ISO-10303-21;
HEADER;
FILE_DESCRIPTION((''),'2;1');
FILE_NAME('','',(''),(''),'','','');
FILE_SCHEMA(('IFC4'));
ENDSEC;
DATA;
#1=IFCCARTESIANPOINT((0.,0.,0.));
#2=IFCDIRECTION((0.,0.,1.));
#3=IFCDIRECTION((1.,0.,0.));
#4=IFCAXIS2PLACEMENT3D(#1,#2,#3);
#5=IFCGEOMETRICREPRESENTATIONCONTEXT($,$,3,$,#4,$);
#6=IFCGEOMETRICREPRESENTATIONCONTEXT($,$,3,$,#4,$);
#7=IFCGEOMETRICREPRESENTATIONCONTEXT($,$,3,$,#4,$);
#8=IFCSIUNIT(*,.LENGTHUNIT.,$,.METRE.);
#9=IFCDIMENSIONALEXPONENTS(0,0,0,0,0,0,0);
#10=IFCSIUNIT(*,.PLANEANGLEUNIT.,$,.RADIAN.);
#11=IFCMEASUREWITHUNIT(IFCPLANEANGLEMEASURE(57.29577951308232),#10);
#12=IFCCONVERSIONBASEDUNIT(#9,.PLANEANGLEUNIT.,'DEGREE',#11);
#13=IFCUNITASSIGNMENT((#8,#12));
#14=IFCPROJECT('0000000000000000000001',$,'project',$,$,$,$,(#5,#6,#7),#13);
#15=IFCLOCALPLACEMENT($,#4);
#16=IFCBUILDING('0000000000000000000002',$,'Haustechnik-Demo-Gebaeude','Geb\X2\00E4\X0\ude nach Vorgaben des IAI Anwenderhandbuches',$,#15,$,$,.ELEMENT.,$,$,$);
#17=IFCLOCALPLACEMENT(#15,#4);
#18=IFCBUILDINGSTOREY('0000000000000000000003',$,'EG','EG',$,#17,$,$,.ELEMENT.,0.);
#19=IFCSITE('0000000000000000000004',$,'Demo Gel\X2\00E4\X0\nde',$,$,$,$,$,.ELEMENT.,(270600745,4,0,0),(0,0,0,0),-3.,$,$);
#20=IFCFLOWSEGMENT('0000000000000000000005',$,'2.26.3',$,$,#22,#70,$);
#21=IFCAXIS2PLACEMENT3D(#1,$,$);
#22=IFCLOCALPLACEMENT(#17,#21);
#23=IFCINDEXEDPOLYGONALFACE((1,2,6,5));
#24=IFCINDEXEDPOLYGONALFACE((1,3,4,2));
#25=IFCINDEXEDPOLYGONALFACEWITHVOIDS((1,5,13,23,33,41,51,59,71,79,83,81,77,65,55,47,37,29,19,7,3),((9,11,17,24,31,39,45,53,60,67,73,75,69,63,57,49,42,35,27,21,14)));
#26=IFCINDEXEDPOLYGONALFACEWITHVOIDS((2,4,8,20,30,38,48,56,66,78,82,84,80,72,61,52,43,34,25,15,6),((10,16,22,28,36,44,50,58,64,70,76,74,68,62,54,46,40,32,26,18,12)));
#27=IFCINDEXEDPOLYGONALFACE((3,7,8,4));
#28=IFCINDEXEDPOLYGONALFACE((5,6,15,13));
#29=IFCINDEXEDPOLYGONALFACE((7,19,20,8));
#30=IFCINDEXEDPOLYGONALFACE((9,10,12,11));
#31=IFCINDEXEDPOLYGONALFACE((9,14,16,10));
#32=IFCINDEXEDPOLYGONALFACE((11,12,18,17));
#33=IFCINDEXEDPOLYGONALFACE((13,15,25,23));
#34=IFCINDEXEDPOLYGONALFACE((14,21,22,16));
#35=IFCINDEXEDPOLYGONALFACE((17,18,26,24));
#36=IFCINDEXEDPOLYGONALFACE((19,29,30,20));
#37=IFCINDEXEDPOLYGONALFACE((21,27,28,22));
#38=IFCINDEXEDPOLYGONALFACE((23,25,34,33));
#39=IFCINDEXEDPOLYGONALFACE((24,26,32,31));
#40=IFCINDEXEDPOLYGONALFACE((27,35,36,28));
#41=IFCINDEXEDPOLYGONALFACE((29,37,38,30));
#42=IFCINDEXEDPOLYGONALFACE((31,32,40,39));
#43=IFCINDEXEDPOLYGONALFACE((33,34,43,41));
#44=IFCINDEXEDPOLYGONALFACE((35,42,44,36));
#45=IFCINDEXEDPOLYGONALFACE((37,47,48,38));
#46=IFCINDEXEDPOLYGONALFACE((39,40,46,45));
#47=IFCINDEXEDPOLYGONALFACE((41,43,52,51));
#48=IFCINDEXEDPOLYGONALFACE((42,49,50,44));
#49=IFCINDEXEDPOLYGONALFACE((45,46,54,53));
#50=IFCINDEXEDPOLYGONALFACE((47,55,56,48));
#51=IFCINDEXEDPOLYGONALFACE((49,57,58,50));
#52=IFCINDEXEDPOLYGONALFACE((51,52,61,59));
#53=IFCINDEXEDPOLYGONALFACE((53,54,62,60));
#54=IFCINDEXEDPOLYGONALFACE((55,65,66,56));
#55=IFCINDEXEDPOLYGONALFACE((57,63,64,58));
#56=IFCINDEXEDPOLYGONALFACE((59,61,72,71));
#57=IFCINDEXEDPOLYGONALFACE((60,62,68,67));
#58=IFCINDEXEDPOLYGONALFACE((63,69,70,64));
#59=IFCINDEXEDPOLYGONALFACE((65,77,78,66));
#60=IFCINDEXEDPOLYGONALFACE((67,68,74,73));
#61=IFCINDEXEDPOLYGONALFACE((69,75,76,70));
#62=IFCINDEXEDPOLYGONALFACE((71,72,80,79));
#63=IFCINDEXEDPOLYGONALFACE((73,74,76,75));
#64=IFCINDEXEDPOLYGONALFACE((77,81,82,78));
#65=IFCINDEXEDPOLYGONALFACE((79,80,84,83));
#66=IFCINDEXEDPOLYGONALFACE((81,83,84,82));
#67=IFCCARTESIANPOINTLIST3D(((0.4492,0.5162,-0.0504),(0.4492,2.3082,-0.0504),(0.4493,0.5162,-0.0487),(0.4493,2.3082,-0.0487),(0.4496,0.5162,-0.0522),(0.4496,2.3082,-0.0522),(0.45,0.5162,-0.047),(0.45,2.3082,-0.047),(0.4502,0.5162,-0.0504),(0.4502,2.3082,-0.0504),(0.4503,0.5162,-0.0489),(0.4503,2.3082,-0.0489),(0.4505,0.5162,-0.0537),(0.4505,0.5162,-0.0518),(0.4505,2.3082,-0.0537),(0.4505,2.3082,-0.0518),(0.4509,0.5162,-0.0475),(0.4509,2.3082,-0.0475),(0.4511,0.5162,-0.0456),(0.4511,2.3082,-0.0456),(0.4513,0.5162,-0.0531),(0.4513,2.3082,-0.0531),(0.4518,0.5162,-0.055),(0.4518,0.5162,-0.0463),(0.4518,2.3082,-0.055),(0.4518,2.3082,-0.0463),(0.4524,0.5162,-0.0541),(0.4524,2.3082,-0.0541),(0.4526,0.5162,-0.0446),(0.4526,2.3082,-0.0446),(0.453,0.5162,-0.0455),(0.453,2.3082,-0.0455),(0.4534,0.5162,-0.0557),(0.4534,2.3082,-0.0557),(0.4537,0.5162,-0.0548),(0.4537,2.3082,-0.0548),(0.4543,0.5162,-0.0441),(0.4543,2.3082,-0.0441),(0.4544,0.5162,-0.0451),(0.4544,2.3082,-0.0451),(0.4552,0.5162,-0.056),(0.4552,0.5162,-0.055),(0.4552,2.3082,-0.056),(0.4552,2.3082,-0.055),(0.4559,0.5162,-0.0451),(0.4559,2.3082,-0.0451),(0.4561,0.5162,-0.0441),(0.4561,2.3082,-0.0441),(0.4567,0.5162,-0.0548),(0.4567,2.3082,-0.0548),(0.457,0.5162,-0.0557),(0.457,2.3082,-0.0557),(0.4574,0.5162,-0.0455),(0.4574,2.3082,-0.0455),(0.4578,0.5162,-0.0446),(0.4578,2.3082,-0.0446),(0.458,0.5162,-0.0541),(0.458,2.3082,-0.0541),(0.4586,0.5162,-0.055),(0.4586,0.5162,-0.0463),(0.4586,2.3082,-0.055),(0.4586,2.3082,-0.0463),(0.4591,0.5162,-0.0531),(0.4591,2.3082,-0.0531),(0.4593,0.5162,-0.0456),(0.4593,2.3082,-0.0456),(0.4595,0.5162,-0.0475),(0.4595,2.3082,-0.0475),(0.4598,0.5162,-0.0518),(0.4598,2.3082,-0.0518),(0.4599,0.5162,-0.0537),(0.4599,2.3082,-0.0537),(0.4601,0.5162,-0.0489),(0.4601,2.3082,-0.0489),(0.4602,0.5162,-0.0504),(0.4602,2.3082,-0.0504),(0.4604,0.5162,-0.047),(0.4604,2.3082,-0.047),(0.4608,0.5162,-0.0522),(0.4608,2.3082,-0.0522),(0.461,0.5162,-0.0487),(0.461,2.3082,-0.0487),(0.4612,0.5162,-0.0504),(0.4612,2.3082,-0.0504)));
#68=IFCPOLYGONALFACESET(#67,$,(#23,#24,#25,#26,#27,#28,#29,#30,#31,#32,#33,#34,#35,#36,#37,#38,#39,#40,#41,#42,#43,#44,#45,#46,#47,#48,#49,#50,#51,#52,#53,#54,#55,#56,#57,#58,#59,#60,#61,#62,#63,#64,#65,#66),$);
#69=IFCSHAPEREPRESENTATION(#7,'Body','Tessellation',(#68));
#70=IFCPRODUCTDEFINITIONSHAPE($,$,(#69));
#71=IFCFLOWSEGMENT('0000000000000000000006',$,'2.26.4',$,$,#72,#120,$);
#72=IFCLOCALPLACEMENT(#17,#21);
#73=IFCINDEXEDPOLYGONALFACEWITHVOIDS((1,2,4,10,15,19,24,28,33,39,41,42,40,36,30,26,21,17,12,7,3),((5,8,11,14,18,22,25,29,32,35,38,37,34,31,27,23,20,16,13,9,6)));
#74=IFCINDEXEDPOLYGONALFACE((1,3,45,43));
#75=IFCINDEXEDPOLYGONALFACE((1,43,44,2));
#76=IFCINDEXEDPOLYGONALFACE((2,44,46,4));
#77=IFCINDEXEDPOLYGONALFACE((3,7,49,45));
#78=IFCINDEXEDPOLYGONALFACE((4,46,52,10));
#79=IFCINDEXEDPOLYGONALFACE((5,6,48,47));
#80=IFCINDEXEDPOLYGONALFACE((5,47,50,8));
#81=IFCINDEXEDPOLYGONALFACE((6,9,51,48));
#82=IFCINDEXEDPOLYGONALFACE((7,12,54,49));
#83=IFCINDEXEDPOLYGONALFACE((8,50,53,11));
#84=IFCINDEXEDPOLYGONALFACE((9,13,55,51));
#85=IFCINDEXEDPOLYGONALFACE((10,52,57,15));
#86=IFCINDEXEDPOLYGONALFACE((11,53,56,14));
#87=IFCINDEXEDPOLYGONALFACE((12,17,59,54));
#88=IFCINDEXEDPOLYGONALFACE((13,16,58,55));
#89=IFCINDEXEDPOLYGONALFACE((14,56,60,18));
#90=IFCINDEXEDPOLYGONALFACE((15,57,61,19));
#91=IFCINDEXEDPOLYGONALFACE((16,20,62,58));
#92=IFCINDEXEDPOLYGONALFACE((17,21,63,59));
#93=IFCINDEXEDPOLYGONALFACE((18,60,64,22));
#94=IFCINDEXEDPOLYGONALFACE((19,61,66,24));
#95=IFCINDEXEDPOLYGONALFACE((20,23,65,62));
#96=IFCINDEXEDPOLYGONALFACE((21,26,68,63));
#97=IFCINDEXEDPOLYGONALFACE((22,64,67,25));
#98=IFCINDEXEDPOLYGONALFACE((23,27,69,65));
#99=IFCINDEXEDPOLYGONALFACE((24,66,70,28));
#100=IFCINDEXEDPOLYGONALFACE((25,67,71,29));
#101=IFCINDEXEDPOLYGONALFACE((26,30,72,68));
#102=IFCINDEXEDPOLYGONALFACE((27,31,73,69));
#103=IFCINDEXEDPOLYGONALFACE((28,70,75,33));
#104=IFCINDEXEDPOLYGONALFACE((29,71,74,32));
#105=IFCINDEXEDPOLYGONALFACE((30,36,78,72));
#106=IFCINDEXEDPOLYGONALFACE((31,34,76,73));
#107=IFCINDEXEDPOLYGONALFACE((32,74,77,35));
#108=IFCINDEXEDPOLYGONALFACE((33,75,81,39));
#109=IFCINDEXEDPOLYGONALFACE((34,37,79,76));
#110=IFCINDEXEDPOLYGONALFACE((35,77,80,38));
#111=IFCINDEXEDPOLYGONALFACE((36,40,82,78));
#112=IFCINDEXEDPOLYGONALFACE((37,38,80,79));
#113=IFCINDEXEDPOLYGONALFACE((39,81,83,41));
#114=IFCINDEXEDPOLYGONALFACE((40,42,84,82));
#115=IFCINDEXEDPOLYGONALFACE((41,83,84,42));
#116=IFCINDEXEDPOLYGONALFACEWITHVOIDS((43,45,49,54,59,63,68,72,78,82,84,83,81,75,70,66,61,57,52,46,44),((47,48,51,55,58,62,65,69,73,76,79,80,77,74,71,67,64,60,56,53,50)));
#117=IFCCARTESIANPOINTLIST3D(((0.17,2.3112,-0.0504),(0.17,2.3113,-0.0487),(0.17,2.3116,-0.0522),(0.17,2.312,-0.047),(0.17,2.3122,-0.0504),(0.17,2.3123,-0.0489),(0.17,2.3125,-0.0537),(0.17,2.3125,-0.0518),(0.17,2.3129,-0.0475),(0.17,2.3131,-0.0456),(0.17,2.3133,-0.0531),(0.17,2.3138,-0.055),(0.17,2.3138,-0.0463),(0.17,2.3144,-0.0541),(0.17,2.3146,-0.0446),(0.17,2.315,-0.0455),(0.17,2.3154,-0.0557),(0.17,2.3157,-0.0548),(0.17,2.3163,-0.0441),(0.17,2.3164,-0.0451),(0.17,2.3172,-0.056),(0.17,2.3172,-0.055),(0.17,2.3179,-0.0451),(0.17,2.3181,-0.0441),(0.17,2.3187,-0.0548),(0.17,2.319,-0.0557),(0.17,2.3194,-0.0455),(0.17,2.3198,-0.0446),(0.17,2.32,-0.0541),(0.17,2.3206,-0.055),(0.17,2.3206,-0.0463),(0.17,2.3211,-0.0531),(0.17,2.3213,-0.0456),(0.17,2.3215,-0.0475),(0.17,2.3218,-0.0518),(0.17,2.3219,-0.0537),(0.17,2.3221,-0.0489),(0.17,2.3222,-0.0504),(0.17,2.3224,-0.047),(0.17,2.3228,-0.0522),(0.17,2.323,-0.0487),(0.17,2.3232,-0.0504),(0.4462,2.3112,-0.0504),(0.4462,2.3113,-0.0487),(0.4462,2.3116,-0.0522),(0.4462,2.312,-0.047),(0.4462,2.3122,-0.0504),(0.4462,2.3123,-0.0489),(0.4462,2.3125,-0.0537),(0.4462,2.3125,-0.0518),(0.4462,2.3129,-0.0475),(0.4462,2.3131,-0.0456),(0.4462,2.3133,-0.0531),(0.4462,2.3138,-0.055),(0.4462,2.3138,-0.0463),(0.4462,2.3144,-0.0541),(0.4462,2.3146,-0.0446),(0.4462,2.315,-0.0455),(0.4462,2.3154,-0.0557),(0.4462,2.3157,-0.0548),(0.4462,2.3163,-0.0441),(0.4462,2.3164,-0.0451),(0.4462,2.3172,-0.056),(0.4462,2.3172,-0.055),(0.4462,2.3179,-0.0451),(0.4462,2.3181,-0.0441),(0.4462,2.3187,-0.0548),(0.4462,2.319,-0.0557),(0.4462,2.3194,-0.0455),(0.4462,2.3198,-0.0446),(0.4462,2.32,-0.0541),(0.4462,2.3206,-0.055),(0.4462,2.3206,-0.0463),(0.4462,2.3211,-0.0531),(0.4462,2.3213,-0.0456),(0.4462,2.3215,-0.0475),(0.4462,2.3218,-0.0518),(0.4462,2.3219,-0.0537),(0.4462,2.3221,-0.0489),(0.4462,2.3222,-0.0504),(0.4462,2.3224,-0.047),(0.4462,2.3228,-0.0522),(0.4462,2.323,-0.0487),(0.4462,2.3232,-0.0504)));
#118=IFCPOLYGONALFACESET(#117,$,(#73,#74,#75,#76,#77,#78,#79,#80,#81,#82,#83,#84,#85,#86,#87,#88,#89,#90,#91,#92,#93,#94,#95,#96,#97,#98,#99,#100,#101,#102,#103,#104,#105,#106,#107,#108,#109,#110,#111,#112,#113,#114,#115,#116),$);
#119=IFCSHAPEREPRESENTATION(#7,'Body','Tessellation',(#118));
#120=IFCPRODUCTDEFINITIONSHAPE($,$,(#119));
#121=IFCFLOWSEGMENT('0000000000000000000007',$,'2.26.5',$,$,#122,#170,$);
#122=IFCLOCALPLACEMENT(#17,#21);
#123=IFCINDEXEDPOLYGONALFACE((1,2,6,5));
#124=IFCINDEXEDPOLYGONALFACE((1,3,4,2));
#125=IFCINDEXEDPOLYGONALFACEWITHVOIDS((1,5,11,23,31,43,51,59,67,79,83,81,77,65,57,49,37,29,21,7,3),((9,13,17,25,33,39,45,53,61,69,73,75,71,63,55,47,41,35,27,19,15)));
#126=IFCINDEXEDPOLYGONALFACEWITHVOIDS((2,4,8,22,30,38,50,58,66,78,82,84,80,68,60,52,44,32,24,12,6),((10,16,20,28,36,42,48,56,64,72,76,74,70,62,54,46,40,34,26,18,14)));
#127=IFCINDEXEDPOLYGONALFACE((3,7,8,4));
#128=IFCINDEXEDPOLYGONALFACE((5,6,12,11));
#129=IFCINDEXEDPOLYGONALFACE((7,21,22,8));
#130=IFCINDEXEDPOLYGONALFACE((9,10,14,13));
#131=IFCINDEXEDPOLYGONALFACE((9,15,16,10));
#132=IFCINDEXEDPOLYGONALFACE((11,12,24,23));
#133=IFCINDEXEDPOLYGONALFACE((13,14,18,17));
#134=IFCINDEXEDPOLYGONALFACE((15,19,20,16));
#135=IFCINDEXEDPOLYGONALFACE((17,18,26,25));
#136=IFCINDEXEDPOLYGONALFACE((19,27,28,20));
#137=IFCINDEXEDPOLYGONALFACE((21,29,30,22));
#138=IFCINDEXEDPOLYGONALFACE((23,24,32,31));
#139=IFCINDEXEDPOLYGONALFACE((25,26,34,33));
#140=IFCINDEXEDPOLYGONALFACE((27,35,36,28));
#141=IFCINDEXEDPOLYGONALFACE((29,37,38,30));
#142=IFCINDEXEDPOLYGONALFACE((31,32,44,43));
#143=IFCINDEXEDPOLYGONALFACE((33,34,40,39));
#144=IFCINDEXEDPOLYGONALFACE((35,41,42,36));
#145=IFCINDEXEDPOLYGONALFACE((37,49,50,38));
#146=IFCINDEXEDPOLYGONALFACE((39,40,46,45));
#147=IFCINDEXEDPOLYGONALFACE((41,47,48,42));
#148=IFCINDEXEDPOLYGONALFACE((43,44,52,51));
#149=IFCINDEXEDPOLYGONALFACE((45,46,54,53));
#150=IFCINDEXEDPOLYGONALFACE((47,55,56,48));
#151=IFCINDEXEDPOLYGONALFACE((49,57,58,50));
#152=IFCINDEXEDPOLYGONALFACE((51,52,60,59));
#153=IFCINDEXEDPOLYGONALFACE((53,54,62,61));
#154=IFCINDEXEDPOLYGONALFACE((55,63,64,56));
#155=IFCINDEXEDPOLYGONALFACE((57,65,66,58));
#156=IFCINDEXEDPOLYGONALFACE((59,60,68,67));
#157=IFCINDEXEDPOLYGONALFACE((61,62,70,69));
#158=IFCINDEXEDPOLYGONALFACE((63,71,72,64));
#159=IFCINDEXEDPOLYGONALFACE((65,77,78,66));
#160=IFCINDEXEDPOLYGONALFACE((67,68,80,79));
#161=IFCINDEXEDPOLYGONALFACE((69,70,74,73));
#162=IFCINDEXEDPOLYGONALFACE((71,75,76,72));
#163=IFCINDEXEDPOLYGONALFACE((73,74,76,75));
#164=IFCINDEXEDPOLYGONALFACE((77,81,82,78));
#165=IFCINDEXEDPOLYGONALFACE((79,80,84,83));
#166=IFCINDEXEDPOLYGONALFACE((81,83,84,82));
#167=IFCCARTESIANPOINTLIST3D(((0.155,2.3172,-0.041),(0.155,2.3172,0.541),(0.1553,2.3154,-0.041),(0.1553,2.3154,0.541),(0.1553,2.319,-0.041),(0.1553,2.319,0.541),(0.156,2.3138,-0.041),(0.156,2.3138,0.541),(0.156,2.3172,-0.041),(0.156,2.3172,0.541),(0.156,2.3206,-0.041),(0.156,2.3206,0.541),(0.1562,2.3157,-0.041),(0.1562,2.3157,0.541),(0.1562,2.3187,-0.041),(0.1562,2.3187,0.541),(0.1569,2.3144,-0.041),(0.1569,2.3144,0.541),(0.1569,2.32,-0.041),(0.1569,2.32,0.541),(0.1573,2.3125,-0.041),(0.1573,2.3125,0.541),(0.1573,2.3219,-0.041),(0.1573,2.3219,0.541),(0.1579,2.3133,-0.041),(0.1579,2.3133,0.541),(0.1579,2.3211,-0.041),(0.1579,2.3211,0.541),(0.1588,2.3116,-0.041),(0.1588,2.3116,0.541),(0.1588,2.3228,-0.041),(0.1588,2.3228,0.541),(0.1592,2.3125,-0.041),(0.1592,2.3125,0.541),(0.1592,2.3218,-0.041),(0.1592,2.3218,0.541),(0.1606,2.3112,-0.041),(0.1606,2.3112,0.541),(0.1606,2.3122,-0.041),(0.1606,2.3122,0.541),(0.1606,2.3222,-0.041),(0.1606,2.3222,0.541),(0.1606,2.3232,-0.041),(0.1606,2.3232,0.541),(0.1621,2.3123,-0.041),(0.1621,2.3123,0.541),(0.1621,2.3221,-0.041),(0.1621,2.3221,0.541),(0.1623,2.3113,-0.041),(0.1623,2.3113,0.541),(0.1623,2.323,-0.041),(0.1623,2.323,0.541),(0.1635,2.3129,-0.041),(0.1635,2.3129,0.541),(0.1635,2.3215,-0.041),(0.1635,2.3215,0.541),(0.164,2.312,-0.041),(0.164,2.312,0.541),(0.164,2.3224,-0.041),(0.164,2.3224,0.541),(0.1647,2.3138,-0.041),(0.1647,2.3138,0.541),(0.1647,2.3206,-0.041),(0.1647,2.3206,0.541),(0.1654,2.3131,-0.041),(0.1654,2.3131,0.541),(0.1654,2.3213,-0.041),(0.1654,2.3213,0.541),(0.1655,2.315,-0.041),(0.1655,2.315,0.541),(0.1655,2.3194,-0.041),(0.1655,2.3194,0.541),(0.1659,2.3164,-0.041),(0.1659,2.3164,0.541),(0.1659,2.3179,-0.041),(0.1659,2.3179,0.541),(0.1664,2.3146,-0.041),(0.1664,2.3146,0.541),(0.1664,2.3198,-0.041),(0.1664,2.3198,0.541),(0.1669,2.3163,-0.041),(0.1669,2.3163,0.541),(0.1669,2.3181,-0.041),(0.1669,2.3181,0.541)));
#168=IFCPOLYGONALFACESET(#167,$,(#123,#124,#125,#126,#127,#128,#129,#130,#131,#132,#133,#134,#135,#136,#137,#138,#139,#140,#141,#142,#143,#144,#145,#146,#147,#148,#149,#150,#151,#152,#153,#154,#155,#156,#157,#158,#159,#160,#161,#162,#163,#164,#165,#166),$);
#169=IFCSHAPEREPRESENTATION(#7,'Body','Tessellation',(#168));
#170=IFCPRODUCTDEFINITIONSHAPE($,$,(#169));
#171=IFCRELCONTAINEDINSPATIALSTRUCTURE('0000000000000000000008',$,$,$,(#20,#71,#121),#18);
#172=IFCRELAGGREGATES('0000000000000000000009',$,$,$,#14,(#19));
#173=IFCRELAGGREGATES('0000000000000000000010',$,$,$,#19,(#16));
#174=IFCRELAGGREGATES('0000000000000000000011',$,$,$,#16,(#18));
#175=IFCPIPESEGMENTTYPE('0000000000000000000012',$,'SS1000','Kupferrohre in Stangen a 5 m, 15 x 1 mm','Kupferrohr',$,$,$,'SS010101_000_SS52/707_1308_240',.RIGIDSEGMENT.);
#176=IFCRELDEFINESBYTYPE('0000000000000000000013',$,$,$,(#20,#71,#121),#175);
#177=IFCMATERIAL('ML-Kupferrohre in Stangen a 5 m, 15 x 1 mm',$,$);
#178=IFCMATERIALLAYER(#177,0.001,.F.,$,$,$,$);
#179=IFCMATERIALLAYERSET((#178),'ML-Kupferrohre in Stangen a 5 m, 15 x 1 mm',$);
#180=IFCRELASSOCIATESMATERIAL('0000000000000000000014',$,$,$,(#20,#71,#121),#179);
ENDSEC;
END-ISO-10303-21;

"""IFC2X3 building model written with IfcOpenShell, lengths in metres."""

from ifc_helpers import new_model, entity, si_unit, converted_unit, frame, origin_with_axes, origin_2d_with_axis, place, context, project, spatial, hollow_circle, extrude, material, layer, layer_set, layer_usage, type_object, element, save


model = new_model("IFC2X3")

# Units and contexts
context_of_model_1 = context(None, 3, world=origin_with_axes())
context_of_model_2 = context(None, 3, world=origin_with_axes())
context_of_model_3 = context(None, 3, world=origin_with_axes())
ifc_project = project(units=[si_unit("LENGTHUNIT", "METRE"), converted_unit("PLANEANGLEUNIT", "DEGREE", entity("IfcPlaneAngleMeasure", 57.29577951308232), si_unit("PLANEANGLEUNIT", "RADIAN"), dimensions=[0, 0, 0, 0, 0, 0, 0])], contexts=[context_of_model_1, context_of_model_2, context_of_model_3])

# Site, building, storey
site = spatial("IfcSite", under=ifc_project, Name="Demo Gelände", CompositionType="ELEMENT", RefLatitude=(270600745, 4, 0, 0), RefLongitude=(0, 0, 0, 0), RefElevation=-3.0)
building_placement = place(None, origin_with_axes())
building = spatial("IfcBuilding", under=site, at=building_placement, Name="Haustechnik-Demo-Gebaeude", Description="Gebäude nach Vorgaben des IAI Anwenderhandbuches", CompositionType="ELEMENT")
storey_placement = place(building_placement, origin_with_axes())
storey = spatial("IfcBuildingStorey", under=building, at=storey_placement, Name="EG", Description="EG", CompositionType="ELEMENT", Elevation=0.0)

# Flow segments
ifc_material = material(Name="ML-Kupferrohre in Stangen a 5 m, 15 x 1 mm")
ifc_layer = layer(ifc_material, 0.001, ventilated=False)
ifc_layer_set = layer_set([ifc_layer], Name="ML-Kupferrohre in Stangen a 5 m, 15 x 1 mm")
ifc_layer_usage = layer_usage(ifc_layer_set, "AXIS2", "POSITIVE", 0.0)
pipe_segment_type_1 = type_object("IfcPipeSegmentType", Name="SS1000", Description="Kupferrohre in Stangen a 5 m, 15 x 1 mm", ApplicableOccurrence="Kupferrohr", ElementType="SS010101_000_SS52/707_1308_240", PredefinedType="RIGIDSEGMENT")
flow_segment_1_placement = place(storey_placement, frame((0.4552, 0.5162, -0.05), z_axis=(0.0, 1.0, 0.0), x_axis=(0.0, 0.0, -1.0)))
element("IfcFlowSegment", 1, at=flow_segment_1_placement, inside=storey, type_object=pipe_segment_type_1, material=ifc_layer_usage, Name="2.26.3", context=context_of_model_3, shape_type="SweptSolid", body=[
    extrude(hollow_circle(Radius=0.006, WallThickness=0.001, at=origin_2d_with_axis()), origin_with_axes(), (0.0, 0.0, 1.0), 1.792),
])
flow_segment_2_placement = place(storey_placement, frame((0.4462, 2.3172, -0.05), z_axis=(-1.0, 0.0, 0.0), x_axis=(0.0, 0.0, -1.0)))
element("IfcFlowSegment", 2, at=flow_segment_2_placement, inside=storey, type_object=pipe_segment_type_1, material=ifc_layer_usage, Name="2.26.4", context=context_of_model_3, shape_type="SweptSolid", body=[
    extrude(hollow_circle(Radius=0.006, WallThickness=0.001, at=origin_2d_with_axis()), origin_with_axes(), (0.0, 0.0, 1.0), 0.2762),
])
flow_segment_3_placement = place(storey_placement, frame((0.161, 2.3172, -0.041), z_axis=(0.0, 0.0, 1.0), x_axis=(-1.0, 0.0, 0.0)))
element("IfcFlowSegment", 3, at=flow_segment_3_placement, inside=storey, type_object=pipe_segment_type_1, material=ifc_layer_usage, Name="2.26.5", context=context_of_model_3, shape_type="SweptSolid", body=[
    extrude(hollow_circle(Radius=0.006, WallThickness=0.001, at=origin_2d_with_axis()), origin_with_axes(), (0.0, 0.0, 1.0), 0.582),
])

save(model, "model.ifc")
